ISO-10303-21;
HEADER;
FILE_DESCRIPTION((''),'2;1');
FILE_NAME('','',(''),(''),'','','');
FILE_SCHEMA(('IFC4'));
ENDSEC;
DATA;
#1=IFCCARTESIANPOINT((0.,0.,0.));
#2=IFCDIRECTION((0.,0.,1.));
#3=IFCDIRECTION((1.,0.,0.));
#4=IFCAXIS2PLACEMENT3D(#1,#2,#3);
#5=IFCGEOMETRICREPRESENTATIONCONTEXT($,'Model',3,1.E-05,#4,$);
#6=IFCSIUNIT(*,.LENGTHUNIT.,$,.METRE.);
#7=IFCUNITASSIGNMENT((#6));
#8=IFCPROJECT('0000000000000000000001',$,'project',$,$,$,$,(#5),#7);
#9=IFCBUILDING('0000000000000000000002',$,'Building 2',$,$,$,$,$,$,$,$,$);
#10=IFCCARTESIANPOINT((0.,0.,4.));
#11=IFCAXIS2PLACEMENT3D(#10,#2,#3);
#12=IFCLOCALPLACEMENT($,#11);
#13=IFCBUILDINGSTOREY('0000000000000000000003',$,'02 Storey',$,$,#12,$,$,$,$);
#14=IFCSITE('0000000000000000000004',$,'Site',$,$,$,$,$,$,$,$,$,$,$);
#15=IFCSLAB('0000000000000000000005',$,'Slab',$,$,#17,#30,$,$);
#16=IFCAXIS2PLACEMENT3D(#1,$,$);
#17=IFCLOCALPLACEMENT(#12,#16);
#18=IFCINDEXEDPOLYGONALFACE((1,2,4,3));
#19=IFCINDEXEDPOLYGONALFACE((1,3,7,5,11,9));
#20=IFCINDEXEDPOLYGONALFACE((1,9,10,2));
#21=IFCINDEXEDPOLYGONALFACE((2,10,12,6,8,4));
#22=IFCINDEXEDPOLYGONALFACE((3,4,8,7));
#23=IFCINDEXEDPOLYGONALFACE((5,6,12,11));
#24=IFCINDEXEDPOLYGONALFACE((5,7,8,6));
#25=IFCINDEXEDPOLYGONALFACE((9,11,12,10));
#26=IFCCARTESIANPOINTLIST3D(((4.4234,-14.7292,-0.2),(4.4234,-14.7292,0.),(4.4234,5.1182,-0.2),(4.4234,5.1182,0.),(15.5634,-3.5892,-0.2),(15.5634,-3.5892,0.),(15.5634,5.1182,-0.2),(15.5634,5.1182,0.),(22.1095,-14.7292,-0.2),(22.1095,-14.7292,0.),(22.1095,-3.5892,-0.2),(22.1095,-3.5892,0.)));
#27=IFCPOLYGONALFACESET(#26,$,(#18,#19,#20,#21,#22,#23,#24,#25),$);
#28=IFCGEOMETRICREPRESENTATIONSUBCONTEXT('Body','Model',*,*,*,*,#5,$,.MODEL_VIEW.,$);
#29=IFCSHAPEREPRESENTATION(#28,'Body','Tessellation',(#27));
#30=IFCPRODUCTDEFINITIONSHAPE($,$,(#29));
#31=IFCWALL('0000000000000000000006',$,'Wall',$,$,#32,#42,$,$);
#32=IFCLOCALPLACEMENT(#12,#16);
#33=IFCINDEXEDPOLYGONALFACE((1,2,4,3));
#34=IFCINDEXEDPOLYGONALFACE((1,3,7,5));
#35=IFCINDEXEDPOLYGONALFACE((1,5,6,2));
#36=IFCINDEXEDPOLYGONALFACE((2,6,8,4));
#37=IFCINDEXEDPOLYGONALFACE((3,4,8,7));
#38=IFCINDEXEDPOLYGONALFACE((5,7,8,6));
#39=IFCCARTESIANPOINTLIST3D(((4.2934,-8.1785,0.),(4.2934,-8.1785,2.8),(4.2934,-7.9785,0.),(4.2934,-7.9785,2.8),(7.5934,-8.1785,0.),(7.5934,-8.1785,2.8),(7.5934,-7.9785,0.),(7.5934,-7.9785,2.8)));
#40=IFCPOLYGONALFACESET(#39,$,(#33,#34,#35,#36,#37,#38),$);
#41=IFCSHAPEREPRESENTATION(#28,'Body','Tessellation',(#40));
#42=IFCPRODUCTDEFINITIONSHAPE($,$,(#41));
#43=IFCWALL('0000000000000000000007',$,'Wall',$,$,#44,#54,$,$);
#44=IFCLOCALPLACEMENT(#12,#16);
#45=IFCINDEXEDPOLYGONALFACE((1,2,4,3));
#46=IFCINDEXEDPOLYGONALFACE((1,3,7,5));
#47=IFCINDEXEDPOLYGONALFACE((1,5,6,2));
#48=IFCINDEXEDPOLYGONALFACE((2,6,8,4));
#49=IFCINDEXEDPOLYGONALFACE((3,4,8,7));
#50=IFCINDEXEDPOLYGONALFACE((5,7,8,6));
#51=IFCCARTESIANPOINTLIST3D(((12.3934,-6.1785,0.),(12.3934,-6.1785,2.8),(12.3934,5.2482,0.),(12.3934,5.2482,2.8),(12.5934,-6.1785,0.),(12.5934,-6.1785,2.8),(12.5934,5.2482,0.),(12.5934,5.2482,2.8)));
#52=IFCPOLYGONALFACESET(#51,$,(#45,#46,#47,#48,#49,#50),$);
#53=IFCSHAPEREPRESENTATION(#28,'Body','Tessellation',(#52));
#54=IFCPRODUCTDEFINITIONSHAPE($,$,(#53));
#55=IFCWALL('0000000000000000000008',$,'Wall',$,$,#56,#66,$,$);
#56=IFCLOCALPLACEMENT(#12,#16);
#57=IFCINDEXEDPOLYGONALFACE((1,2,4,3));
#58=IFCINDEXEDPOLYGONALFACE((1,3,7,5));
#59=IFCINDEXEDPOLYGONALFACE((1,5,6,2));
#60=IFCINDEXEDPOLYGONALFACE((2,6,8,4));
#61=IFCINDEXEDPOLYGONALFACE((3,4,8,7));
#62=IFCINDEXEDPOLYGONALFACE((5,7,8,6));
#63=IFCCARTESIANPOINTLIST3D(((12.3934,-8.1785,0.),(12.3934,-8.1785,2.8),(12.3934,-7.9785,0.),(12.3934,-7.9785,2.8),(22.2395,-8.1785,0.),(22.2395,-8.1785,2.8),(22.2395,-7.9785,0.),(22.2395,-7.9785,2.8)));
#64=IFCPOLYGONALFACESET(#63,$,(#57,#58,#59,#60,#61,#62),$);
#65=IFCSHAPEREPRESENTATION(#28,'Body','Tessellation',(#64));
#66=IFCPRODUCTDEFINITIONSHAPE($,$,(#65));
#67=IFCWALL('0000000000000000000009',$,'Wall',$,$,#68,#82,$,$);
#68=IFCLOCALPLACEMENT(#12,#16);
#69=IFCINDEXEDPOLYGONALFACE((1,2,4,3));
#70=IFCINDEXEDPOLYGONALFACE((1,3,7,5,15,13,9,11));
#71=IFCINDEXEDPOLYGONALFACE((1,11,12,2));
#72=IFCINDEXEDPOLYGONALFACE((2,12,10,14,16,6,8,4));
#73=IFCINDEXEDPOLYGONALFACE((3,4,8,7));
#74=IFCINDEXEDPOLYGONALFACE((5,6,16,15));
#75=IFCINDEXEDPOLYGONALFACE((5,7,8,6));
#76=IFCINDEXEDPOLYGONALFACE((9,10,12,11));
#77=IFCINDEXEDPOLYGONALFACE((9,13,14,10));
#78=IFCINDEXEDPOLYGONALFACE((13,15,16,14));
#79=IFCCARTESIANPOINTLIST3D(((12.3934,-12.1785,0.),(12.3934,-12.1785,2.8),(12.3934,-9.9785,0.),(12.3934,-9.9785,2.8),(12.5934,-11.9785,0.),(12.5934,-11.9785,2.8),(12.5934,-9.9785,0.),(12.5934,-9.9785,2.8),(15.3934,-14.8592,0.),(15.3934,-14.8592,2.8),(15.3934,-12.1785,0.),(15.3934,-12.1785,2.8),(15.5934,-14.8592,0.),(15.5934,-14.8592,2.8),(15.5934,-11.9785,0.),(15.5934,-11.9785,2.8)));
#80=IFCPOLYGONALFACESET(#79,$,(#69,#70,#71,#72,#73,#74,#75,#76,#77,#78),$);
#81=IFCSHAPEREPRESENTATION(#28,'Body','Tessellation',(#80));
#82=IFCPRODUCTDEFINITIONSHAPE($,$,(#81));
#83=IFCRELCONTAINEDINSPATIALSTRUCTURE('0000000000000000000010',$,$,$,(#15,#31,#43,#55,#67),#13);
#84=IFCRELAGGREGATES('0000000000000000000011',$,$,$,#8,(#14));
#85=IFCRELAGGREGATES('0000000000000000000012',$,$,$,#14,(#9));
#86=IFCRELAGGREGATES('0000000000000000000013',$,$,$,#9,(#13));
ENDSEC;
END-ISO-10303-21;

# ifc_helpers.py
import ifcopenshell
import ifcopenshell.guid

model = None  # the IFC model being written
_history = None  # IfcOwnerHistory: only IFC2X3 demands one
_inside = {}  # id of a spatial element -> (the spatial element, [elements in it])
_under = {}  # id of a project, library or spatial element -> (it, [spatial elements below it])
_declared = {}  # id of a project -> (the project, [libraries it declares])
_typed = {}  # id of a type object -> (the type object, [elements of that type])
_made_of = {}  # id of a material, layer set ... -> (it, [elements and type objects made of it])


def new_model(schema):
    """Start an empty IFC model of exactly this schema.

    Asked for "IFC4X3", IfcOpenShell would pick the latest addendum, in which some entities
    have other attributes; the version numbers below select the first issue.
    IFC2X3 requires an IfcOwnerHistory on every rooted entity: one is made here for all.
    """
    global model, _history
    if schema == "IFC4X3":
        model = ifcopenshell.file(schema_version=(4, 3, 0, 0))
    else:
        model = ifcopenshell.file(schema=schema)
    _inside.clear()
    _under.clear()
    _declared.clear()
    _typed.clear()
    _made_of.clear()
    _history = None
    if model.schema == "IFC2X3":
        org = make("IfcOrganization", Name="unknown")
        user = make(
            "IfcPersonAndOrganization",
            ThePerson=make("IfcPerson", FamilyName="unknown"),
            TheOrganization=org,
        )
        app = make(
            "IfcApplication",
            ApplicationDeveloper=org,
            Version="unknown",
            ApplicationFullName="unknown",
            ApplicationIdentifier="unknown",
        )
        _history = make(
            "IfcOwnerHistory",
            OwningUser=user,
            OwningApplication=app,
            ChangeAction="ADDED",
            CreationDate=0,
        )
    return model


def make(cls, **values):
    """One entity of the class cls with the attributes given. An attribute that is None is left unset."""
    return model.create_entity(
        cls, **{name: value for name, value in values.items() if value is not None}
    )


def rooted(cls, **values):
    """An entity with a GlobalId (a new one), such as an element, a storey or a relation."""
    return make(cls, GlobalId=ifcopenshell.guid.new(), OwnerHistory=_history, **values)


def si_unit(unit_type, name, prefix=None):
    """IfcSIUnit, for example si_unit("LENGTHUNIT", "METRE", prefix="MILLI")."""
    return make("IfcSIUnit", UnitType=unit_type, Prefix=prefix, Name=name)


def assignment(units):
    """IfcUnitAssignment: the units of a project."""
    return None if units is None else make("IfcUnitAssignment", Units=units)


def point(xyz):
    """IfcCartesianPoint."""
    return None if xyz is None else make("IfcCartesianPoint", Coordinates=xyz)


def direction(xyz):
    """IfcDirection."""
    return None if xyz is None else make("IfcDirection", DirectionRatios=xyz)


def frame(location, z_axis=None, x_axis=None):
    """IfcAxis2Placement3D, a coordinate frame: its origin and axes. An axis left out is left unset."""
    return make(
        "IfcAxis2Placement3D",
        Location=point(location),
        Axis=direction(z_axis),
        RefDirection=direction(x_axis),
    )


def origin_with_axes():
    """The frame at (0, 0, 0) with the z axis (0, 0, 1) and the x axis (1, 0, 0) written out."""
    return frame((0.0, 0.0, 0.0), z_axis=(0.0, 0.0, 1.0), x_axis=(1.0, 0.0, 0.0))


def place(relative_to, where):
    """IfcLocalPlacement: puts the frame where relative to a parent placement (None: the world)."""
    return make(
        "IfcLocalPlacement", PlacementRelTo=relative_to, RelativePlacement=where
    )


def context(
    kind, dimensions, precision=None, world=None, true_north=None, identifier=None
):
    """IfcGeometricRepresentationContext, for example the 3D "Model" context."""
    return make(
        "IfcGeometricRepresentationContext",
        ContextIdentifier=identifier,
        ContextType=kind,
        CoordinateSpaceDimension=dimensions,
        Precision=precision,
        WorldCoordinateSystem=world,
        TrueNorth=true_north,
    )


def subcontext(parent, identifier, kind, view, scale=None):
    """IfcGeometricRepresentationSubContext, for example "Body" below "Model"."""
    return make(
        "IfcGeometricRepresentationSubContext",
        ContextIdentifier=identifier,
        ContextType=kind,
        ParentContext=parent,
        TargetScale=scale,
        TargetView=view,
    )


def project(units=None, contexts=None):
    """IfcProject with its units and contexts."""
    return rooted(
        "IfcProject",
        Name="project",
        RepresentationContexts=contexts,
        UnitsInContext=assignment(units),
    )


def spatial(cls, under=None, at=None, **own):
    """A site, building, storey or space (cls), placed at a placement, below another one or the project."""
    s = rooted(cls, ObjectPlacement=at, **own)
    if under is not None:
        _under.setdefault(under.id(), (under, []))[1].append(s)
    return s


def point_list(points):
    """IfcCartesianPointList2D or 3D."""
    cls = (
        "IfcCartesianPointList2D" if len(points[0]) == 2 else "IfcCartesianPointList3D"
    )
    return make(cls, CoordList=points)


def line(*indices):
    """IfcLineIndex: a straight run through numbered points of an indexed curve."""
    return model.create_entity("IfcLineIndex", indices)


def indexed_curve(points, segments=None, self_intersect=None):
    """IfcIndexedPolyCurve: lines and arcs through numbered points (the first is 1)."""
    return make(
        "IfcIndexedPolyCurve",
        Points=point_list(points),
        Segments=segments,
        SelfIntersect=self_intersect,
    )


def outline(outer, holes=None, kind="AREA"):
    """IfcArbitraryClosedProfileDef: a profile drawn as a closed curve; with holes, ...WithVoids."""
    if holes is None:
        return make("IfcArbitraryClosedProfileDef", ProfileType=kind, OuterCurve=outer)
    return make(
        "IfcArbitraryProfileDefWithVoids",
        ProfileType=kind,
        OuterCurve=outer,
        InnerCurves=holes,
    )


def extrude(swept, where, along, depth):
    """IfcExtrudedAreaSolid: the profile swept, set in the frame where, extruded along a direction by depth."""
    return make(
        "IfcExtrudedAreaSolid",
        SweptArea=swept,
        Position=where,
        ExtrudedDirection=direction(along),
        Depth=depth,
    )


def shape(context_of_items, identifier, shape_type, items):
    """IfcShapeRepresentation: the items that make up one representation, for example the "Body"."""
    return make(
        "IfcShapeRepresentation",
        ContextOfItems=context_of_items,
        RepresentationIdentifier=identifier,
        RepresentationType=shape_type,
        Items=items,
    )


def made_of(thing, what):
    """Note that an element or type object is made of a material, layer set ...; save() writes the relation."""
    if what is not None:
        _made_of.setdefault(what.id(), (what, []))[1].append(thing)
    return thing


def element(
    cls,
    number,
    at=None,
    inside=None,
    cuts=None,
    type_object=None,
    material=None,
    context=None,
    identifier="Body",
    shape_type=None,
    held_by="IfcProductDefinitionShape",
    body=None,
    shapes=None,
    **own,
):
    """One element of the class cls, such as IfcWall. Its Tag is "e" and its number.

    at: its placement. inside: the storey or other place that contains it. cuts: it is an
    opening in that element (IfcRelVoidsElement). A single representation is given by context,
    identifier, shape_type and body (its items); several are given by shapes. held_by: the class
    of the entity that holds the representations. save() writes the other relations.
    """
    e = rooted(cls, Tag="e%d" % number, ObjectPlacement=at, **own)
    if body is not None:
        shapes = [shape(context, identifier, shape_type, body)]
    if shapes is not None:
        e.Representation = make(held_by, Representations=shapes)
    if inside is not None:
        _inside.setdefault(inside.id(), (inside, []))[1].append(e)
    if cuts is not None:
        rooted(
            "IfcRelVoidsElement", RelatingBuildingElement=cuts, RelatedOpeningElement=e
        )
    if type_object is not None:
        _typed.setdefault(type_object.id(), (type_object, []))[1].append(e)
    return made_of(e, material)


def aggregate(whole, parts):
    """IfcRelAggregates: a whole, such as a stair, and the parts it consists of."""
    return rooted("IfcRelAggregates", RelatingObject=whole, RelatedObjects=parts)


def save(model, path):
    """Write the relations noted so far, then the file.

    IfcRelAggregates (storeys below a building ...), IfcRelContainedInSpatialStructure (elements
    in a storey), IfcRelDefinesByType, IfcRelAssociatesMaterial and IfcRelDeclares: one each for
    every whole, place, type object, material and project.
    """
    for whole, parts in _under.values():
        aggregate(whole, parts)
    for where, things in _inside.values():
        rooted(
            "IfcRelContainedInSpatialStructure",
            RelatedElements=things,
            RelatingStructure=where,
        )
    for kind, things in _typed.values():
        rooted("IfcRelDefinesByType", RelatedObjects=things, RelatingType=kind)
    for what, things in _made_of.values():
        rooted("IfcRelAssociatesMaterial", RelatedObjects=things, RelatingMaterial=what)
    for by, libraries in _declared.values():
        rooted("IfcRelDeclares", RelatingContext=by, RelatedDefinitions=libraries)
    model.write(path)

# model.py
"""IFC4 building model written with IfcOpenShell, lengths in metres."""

from ifc_helpers import new_model, si_unit, frame, origin_with_axes, place, context, subcontext, project, spatial, line, indexed_curve, outline, extrude, element, save


model = new_model("IFC4")

# Units and contexts
model_context = context("Model", 3, precision=1e-05, world=origin_with_axes())
body_context = subcontext(model_context, "Body", "Model", "MODEL_VIEW")
ifc_project = project(units=[si_unit("LENGTHUNIT", "METRE")], contexts=[model_context])

# Site, building, storey
site = spatial("IfcSite", under=ifc_project, Name="Site")
building = spatial("IfcBuilding", under=site, Name="Building 2")
storey_placement = place(None, frame((0.0, 0.0, 4.0), z_axis=(0.0, 0.0, 1.0), x_axis=(1.0, 0.0, 0.0)))
storey = spatial("IfcBuildingStorey", under=building, at=storey_placement, Name="02 Storey")

# Slab
slab_placement = place(storey_placement, origin_with_axes())
element("IfcSlab", 1, at=slab_placement, inside=storey, Name="Slab", context=body_context, shape_type="SweptSolid", body=[
    extrude(outline(indexed_curve([(22.1095, -3.5892), (15.5634, -3.5892), (15.5634, 5.1182), (4.4234, 5.1182), (4.4234, -14.7292), (22.1095, -14.7292)], segments=[line(1, 2), line(2, 3), line(3, 4), line(4, 5), line(5, 6)])), origin_with_axes(), (0.0, 0.0, -1.0), 0.2),
])

# Walls
wall_1_placement = place(storey_placement, origin_with_axes())
element("IfcWall", 2, at=wall_1_placement, inside=storey, Name="Wall", context=body_context, shape_type="SweptSolid", body=[
    extrude(outline(indexed_curve([(7.5934, -7.9785), (4.2934, -7.9785), (4.2934, -8.1785), (7.5934, -8.1785)], segments=[line(1, 2), line(2, 3), line(3, 4)])), origin_with_axes(), (0.0, 0.0, 1.0), 2.8),
])
wall_2_placement = place(storey_placement, origin_with_axes())
element("IfcWall", 3, at=wall_2_placement, inside=storey, Name="Wall", context=body_context, shape_type="SweptSolid", body=[
    extrude(outline(indexed_curve([(12.5934, 5.2482), (12.3934, 5.2482), (12.3934, -6.1785), (12.5934, -6.1785)], segments=[line(1, 2), line(2, 3), line(3, 4)])), origin_with_axes(), (0.0, 0.0, 1.0), 2.8),
])
wall_3_placement = place(storey_placement, origin_with_axes())
element("IfcWall", 4, at=wall_3_placement, inside=storey, Name="Wall", context=body_context, shape_type="SweptSolid", body=[
    extrude(outline(indexed_curve([(22.2395, -7.9785), (12.3934, -7.9785), (12.3934, -8.1785), (22.2395, -8.1785)], segments=[line(1, 2), line(2, 3), line(3, 4)])), origin_with_axes(), (0.0, 0.0, 1.0), 2.8),
])
wall_4_placement = place(storey_placement, origin_with_axes())
element("IfcWall", 5, at=wall_4_placement, inside=storey, Name="Wall", context=body_context, shape_type="SweptSolid", body=[
    extrude(outline(indexed_curve([(15.5934, -11.9785), (12.5934, -11.9785), (12.5934, -9.9785), (12.3934, -9.9785), (12.3934, -12.1785), (15.3934, -12.1785), (15.3934, -14.8592), (15.5934, -14.8592)], segments=[line(1, 2), line(2, 3), line(3, 4), line(4, 5), line(5, 6), line(6, 7), line(7, 8)])), origin_with_axes(), (0.0, 0.0, 1.0), 2.8),
])

save(model, "model.ifc")
